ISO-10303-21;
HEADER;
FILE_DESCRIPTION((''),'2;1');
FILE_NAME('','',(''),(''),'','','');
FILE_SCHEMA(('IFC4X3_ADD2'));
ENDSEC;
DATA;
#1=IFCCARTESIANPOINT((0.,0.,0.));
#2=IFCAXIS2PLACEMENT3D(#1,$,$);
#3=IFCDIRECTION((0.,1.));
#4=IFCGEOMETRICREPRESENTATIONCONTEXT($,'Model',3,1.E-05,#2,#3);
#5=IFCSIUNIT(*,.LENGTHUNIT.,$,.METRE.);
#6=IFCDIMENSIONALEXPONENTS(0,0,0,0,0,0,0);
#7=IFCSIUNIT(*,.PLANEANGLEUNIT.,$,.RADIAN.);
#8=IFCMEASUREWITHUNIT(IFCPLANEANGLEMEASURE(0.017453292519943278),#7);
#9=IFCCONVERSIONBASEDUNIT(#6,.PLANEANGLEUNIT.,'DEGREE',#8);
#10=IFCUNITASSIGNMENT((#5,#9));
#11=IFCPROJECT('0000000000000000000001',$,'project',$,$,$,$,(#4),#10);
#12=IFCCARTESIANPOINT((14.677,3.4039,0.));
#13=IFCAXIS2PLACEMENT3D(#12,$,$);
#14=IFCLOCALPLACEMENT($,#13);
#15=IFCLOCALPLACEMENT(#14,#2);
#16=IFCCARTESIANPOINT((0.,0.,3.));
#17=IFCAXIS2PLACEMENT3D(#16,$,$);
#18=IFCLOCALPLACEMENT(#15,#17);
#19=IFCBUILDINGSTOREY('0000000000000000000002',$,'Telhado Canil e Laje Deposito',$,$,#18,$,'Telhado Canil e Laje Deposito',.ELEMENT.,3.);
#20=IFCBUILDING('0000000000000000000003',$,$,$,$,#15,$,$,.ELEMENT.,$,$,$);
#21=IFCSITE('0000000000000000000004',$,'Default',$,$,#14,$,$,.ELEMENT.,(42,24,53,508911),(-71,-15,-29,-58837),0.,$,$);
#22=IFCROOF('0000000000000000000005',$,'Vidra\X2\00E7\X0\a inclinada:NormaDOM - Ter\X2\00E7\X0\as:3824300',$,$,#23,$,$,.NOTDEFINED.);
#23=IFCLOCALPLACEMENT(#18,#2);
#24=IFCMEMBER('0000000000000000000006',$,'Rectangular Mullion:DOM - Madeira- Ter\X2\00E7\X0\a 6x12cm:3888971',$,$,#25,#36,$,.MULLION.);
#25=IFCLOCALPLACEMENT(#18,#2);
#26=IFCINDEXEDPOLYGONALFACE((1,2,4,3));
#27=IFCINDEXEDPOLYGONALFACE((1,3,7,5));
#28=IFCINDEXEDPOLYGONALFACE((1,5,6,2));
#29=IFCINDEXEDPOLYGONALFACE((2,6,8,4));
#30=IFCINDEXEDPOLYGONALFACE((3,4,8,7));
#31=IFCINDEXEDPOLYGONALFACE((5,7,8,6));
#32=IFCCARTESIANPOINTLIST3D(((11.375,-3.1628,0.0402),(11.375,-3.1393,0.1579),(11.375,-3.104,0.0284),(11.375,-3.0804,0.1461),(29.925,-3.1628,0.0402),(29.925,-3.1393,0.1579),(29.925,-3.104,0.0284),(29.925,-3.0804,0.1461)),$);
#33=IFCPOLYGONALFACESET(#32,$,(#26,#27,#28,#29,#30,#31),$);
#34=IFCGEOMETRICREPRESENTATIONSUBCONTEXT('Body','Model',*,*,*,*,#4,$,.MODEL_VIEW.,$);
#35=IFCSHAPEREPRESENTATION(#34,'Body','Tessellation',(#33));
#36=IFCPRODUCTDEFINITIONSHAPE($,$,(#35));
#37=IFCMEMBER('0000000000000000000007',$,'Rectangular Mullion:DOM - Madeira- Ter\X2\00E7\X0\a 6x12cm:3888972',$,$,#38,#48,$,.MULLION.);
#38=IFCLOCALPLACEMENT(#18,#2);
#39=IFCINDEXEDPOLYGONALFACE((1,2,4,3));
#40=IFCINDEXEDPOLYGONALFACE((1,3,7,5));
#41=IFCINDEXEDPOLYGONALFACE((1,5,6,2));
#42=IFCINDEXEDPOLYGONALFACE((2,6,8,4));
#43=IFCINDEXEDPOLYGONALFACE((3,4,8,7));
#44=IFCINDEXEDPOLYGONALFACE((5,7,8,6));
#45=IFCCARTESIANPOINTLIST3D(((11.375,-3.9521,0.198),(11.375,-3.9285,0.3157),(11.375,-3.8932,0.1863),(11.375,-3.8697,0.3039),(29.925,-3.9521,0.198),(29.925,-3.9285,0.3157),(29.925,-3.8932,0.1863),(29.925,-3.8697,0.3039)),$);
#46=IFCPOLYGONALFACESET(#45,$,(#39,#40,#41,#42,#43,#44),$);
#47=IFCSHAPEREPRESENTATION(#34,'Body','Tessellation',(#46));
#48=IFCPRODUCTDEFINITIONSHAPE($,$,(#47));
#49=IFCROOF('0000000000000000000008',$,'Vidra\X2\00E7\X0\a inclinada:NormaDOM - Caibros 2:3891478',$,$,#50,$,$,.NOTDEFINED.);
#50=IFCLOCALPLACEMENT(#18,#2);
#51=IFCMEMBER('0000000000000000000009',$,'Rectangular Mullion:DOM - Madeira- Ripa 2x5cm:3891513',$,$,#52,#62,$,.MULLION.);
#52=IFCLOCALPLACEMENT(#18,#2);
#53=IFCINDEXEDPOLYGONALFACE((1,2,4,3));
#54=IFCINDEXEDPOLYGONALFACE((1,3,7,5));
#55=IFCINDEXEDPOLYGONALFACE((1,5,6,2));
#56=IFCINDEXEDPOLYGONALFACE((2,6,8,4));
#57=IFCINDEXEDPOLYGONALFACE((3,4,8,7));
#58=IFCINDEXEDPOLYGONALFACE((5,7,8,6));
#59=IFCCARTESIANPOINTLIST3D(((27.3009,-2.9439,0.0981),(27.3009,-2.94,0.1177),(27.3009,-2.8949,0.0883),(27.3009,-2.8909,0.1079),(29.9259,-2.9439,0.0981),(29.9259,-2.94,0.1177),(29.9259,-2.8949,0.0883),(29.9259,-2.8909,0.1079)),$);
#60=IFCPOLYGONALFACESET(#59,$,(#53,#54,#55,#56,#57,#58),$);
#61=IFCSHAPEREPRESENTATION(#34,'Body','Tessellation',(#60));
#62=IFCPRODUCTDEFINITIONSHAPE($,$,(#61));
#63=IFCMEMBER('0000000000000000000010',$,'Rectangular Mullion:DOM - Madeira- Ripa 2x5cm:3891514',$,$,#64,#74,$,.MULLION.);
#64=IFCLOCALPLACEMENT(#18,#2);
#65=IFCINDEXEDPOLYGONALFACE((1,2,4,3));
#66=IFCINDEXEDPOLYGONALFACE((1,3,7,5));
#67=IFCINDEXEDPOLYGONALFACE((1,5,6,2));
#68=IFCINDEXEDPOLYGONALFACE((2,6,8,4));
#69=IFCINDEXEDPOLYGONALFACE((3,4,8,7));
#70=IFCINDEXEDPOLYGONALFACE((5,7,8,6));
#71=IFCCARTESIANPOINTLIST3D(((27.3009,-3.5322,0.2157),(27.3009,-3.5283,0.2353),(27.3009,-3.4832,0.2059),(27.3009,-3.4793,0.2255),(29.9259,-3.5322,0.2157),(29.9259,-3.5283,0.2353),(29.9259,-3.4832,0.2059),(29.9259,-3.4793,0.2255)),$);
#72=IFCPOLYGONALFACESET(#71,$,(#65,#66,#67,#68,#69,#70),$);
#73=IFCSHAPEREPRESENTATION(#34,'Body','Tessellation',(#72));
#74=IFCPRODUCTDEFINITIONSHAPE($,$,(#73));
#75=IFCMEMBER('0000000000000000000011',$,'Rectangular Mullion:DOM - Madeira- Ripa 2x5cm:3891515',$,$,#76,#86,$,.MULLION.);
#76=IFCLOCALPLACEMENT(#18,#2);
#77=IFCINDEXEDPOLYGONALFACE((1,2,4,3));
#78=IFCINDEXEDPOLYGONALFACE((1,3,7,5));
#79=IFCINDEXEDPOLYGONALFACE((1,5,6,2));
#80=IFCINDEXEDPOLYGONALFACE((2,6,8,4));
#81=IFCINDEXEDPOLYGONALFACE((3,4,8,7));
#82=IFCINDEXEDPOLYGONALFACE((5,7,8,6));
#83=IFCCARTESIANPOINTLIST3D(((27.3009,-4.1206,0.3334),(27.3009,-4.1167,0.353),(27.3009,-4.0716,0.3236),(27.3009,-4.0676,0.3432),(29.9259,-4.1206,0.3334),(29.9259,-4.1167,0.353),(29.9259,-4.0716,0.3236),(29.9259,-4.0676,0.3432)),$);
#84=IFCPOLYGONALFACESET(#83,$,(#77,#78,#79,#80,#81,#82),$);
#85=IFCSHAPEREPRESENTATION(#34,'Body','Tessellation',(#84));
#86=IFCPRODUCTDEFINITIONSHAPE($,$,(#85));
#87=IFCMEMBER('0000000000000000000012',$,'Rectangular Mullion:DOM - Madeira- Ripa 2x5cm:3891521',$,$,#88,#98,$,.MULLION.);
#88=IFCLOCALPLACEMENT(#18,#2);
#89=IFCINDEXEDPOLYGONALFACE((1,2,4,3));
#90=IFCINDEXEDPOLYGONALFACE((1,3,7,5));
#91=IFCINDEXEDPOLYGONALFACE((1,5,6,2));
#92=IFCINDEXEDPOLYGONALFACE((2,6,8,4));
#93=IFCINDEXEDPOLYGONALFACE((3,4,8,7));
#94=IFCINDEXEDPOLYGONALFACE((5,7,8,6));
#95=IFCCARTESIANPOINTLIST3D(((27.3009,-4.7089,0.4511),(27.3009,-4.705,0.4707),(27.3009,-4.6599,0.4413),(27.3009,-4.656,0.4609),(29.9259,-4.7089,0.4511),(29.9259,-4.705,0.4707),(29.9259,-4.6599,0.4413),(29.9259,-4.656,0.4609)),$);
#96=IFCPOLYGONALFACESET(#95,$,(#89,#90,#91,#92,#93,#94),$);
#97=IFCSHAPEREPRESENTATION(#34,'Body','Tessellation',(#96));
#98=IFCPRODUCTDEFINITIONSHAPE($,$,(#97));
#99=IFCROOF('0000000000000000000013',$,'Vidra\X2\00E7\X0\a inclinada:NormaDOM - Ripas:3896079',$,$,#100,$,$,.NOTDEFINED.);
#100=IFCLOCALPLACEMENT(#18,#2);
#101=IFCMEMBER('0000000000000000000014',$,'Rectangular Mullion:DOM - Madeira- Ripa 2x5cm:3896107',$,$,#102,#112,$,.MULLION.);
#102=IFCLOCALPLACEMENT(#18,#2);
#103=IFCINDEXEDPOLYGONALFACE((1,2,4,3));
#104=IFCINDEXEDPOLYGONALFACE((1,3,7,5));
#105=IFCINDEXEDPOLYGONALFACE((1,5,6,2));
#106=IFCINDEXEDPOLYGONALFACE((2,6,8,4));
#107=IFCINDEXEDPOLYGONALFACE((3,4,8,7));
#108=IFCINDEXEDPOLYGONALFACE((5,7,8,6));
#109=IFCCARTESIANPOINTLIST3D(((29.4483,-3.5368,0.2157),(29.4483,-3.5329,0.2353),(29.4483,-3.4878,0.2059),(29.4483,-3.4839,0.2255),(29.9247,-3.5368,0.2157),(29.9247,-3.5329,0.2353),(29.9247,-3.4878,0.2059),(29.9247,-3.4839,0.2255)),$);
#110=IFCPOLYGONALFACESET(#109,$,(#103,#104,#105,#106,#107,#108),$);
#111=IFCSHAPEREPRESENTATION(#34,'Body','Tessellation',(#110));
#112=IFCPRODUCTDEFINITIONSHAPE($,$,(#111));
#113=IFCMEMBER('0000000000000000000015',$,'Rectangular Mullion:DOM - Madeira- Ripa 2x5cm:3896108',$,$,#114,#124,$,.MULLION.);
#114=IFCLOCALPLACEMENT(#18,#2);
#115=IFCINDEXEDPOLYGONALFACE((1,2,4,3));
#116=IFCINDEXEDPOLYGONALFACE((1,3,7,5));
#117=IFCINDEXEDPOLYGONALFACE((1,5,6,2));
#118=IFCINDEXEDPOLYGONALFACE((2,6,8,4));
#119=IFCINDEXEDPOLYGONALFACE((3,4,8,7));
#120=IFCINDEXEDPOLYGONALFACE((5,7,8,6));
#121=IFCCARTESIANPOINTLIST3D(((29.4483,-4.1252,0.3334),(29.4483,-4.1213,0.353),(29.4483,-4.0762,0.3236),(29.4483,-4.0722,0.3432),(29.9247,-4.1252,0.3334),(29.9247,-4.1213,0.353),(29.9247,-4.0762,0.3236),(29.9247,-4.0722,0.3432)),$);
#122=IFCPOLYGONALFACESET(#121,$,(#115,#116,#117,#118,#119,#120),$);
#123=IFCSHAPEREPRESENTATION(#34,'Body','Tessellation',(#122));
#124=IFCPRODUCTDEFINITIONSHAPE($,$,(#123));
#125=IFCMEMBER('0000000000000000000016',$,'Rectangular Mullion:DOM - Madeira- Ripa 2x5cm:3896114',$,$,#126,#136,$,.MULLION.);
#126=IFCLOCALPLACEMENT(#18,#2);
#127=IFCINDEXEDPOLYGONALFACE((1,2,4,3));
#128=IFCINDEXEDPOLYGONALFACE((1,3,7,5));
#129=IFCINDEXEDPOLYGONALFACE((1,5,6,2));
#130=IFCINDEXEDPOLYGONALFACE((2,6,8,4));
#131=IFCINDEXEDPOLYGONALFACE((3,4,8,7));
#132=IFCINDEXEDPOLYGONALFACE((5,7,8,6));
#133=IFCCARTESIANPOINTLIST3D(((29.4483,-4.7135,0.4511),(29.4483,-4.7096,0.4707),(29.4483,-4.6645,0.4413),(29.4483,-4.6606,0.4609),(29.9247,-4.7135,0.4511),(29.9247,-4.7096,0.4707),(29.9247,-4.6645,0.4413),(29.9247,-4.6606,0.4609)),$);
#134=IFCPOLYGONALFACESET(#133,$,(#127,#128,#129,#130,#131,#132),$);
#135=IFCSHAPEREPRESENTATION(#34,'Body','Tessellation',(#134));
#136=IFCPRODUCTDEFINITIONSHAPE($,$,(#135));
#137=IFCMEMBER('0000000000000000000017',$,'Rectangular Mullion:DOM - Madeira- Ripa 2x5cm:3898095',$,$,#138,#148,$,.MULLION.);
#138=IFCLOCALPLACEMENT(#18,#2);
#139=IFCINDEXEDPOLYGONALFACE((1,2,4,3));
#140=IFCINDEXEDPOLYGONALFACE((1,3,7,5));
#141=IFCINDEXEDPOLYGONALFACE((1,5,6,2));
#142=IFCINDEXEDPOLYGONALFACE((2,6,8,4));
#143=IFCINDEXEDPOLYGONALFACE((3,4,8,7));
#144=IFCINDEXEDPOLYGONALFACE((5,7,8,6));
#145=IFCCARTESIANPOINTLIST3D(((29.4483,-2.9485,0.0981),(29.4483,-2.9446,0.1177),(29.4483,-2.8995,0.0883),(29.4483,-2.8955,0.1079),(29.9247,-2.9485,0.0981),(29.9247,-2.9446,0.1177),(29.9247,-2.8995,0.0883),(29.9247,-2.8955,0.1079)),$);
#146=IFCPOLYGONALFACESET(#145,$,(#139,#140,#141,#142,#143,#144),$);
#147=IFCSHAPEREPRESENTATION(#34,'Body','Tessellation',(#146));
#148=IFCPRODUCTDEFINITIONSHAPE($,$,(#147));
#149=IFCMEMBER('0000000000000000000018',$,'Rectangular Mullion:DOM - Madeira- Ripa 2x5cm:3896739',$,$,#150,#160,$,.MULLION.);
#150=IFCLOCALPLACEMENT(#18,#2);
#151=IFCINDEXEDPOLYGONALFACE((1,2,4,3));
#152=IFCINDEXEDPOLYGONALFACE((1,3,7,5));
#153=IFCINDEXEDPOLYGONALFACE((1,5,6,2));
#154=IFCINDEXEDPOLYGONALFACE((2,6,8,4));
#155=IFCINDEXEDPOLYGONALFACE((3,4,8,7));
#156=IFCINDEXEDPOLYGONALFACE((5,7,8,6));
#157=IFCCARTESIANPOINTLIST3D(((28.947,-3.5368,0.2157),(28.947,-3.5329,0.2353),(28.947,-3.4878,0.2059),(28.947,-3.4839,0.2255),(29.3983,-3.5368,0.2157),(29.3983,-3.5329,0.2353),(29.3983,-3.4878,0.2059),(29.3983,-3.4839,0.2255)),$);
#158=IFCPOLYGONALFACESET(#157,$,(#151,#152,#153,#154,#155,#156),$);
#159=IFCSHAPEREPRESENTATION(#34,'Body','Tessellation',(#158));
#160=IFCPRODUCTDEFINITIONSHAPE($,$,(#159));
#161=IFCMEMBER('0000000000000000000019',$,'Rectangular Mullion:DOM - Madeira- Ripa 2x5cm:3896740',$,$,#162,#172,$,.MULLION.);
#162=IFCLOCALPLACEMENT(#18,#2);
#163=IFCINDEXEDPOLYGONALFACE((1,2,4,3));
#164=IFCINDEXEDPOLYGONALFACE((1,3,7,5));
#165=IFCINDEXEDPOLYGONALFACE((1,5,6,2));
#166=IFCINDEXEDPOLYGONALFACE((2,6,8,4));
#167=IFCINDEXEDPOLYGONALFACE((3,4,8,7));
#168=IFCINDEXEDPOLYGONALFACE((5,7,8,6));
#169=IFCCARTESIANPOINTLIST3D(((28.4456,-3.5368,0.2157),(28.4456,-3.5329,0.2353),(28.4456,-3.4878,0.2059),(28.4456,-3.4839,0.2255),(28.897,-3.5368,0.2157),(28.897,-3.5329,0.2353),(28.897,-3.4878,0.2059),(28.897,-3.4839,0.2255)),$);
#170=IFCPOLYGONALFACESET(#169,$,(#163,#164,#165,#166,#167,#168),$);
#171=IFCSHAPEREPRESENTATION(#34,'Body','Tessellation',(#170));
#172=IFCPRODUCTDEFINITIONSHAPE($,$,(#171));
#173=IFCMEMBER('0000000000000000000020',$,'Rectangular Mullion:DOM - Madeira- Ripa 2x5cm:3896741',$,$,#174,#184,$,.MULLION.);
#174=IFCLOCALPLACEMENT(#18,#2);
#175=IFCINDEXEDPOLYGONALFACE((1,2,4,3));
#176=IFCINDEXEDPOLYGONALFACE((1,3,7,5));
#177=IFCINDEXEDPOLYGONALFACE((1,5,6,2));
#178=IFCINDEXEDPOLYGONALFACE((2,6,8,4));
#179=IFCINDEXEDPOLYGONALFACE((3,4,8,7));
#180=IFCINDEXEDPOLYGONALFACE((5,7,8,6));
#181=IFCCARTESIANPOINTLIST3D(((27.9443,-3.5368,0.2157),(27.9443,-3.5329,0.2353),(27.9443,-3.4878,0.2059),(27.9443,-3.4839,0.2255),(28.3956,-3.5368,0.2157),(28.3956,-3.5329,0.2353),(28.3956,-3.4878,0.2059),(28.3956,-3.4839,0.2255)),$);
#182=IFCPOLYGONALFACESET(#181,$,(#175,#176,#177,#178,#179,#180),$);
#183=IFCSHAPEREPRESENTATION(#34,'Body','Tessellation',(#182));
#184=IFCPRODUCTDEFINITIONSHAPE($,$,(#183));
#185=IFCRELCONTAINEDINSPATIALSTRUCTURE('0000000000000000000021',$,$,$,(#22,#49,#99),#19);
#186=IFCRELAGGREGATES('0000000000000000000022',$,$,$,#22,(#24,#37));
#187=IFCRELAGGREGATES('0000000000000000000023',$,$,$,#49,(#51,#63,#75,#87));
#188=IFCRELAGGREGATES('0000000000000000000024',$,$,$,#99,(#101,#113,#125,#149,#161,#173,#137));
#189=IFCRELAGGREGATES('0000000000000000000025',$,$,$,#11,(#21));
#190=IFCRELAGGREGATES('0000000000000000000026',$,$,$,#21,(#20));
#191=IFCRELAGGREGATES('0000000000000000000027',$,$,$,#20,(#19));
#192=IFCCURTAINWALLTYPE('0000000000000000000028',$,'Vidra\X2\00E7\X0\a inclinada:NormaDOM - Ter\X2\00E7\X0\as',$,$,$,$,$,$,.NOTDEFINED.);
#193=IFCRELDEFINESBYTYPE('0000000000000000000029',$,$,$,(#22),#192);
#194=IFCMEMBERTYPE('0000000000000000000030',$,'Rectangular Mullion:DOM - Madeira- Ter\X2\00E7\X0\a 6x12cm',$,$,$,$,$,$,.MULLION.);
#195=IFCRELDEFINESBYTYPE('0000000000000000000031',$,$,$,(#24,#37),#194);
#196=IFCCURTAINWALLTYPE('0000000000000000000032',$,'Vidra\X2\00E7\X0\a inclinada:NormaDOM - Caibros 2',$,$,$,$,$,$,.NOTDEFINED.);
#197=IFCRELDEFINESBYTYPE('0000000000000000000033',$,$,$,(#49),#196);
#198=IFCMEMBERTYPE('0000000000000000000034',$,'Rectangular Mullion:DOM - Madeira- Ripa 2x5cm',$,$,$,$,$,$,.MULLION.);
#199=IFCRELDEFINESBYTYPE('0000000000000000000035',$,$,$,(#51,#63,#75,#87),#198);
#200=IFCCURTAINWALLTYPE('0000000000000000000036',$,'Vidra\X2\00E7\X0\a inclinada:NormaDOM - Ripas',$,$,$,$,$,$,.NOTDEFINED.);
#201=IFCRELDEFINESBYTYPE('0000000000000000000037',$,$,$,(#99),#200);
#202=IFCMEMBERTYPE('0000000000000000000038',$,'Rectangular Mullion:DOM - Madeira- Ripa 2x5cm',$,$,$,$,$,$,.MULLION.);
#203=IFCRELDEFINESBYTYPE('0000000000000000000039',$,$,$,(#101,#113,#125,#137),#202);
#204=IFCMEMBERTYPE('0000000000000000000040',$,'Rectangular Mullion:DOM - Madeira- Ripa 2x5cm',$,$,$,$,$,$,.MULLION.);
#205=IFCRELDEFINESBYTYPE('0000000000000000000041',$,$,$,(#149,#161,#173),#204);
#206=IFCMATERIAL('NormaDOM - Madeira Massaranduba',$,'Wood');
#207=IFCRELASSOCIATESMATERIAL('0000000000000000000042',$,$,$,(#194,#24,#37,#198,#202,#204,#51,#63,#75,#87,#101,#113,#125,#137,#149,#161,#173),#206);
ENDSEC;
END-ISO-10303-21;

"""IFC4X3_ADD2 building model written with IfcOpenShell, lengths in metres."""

from ifc_helpers import new_model, entity, si_unit, converted_unit, direction, frame, origin, origin_2d_with_axis, place, context, subcontext, project, spatial, rectangle, extrude, source, transform, mapped, material, material_profile, profile_set, profile_usage, type_object, type_shapes, element, aggregate, save


model = new_model("IFC4X3_ADD2")

# Units and contexts
model_context = context("Model", 3, precision=1e-05, world=origin(), true_north=direction((0.0, 1.0)))
body_context = subcontext(model_context, "Body", "Model", "MODEL_VIEW")
ifc_project = project(units=[si_unit("LENGTHUNIT", "METRE"), converted_unit("PLANEANGLEUNIT", "DEGREE", entity("IfcPlaneAngleMeasure", 0.017453292519943278), si_unit("PLANEANGLEUNIT", "RADIAN"), dimensions=[0, 0, 0, 0, 0, 0, 0])], contexts=[model_context])

# Site, building, storey
site_placement = place(None, frame((14.677, 3.4039, 0.0)))
site = spatial("IfcSite", under=ifc_project, at=site_placement, Name="Default", CompositionType="ELEMENT", RefLatitude=(42, 24, 53, 508911), RefLongitude=(-71, -15, -29, -58837), RefElevation=0.0)
building_placement = place(site_placement, origin())
building = spatial("IfcBuilding", under=site, at=building_placement, CompositionType="ELEMENT")
storey_placement = place(building_placement, frame((0.0, 0.0, 3.0)))
storey = spatial("IfcBuildingStorey", under=building, at=storey_placement, Name="Telhado Canil e Laje Deposito", LongName="Telhado Canil e Laje Deposito", CompositionType="ELEMENT", Elevation=3.0)

# Roofs, members
curtain_wall_type_1 = type_object("IfcCurtainWallType", Name="Vidraça inclinada:NormaDOM - Terças", PredefinedType="NOTDEFINED")
roof_1_placement = place(storey_placement, frame((0.0, 0.0, -3.0)))
roof_1 = element("IfcRoof", 1, at=roof_1_placement, inside=storey, type_object=curtain_wall_type_1, Name="Vidraça inclinada:NormaDOM - Terças:3824300", PredefinedType="NOTDEFINED")
ifc_material = material(Name="NormaDOM - Madeira Massaranduba", Category="Wood")
ifc_material_profile_1 = material_profile(ifc_material, rectangle(XDim=0.06, YDim=0.12, at=origin_2d_with_axis()), Name="DOM - Madeira- Terça 6x12cm")
ifc_profile_set_1 = profile_set([ifc_material_profile_1], Name="DOM - Madeira- Terça 6x12cm")
ifc_profile_usage_1 = profile_usage(ifc_profile_set_1)
member_type_1 = type_object("IfcMemberType", Name="Rectangular Mullion:DOM - Madeira- Terça 6x12cm", PredefinedType="MULLION", material=ifc_profile_set_1)
shared_shape_1 = source(origin(), body_context, "Body", "SweptSolid", [
    extrude(rectangle(XDim=0.06, YDim=0.12, at=origin_2d_with_axis()), frame((0.0, 0.06, -18.55), z_axis=(0.0, 0.0, 1.0), x_axis=(-1.0, 0.0, 0.0)), (0.0, 0.0, 1.0), 18.55),
])
type_shapes(member_type_1, [shared_shape_1])
member_1_placement = place(roof_1_placement, frame((29.925, -3.1098, 3.152), z_axis=(1.0, 0.0, 0.0), x_axis=(0.0, -0.980581, 0.196116)))
member_1 = element("IfcMember", 2, at=member_1_placement, type_object=member_type_1, material=ifc_profile_usage_1, Name="Rectangular Mullion:DOM - Madeira- Terça 6x12cm:3888971", PredefinedType="MULLION", context=body_context, shape_type="MappedRepresentation", body=[
    mapped(shared_shape_1, transform((0.0, 0.0, 0.0), scale=1.0)),
])
member_2_placement = place(roof_1_placement, frame((29.925, -3.8991, 3.3098), z_axis=(1.0, 0.0, 0.0), x_axis=(0.0, -0.980581, 0.196116)))
member_2 = element("IfcMember", 3, at=member_2_placement, type_object=member_type_1, material=ifc_profile_usage_1, Name="Rectangular Mullion:DOM - Madeira- Terça 6x12cm:3888972", PredefinedType="MULLION", context=body_context, shape_type="MappedRepresentation", body=[
    mapped(shared_shape_1, transform((0.0, 0.0, 0.0), scale=1.0)),
])
aggregate(roof_1, [member_1, member_2])
curtain_wall_type_2 = type_object("IfcCurtainWallType", Name="Vidraça inclinada:NormaDOM - Caibros 2", PredefinedType="NOTDEFINED")
roof_2_placement = place(storey_placement, frame((0.0, 0.0, -3.0)))
roof_2 = element("IfcRoof", 4, at=roof_2_placement, inside=storey, type_object=curtain_wall_type_2, Name="Vidraça inclinada:NormaDOM - Caibros 2:3891478", PredefinedType="NOTDEFINED")
ifc_material_profile_2 = material_profile(ifc_material, rectangle(XDim=0.05, YDim=0.02, at=origin_2d_with_axis()), Name="DOM - Madeira- Ripa 2x5cm")
ifc_profile_set_2 = profile_set([ifc_material_profile_2], Name="DOM - Madeira- Ripa 2x5cm")
ifc_profile_usage_2 = profile_usage(ifc_profile_set_2)
member_type_2 = type_object("IfcMemberType", Name="Rectangular Mullion:DOM - Madeira- Ripa 2x5cm", PredefinedType="MULLION", material=ifc_profile_set_2)
shared_shape_2 = source(origin(), body_context, "Body", "SweptSolid", [
    extrude(rectangle(XDim=0.05, YDim=0.02, at=origin_2d_with_axis()), frame((0.025, 0.01, -2.625), z_axis=(0.0, 0.0, 1.0), x_axis=(-1.0, 0.0, 0.0)), (0.0, 0.0, 1.0), 2.625),
])
type_shapes(member_type_2, [shared_shape_2])
member_3_placement = place(roof_2_placement, frame((29.9259, -2.8909, 3.1079), z_axis=(1.0, 0.0, 0.0), x_axis=(0.0, -0.980581, 0.196116)))
member_3 = element("IfcMember", 5, at=member_3_placement, type_object=member_type_2, material=ifc_profile_usage_2, Name="Rectangular Mullion:DOM - Madeira- Ripa 2x5cm:3891513", PredefinedType="MULLION", context=body_context, shape_type="MappedRepresentation", body=[
    mapped(shared_shape_2, transform((0.0, 0.0, 0.0), scale=1.0)),
])
member_4_placement = place(roof_2_placement, frame((29.9259, -3.4793, 3.2255), z_axis=(1.0, 0.0, 0.0), x_axis=(0.0, -0.980581, 0.196116)))
member_4 = element("IfcMember", 6, at=member_4_placement, type_object=member_type_2, material=ifc_profile_usage_2, Name="Rectangular Mullion:DOM - Madeira- Ripa 2x5cm:3891514", PredefinedType="MULLION", context=body_context, shape_type="MappedRepresentation", body=[
    mapped(shared_shape_2, transform((0.0, 0.0, 0.0), scale=1.0)),
])
member_5_placement = place(roof_2_placement, frame((29.9259, -4.0676, 3.3432), z_axis=(1.0, 0.0, 0.0), x_axis=(0.0, -0.980581, 0.196116)))
member_5 = element("IfcMember", 7, at=member_5_placement, type_object=member_type_2, material=ifc_profile_usage_2, Name="Rectangular Mullion:DOM - Madeira- Ripa 2x5cm:3891515", PredefinedType="MULLION", context=body_context, shape_type="MappedRepresentation", body=[
    mapped(shared_shape_2, transform((0.0, 0.0, 0.0), scale=1.0)),
])
member_6_placement = place(roof_2_placement, frame((29.9259, -4.656, 3.4609), z_axis=(1.0, 0.0, 0.0), x_axis=(0.0, -0.980581, 0.196116)))
member_6 = element("IfcMember", 8, at=member_6_placement, type_object=member_type_2, material=ifc_profile_usage_2, Name="Rectangular Mullion:DOM - Madeira- Ripa 2x5cm:3891521", PredefinedType="MULLION", context=body_context, shape_type="MappedRepresentation", body=[
    mapped(shared_shape_2, transform((0.0, 0.0, 0.0), scale=1.0)),
])
aggregate(roof_2, [member_3, member_4, member_5, member_6])
curtain_wall_type_3 = type_object("IfcCurtainWallType", Name="Vidraça inclinada:NormaDOM - Ripas", PredefinedType="NOTDEFINED")
roof_3_placement = place(storey_placement, frame((0.0, 0.0, -3.0)))
roof_3 = element("IfcRoof", 9, at=roof_3_placement, inside=storey, type_object=curtain_wall_type_3, Name="Vidraça inclinada:NormaDOM - Ripas:3896079", PredefinedType="NOTDEFINED")
member_type_3 = type_object("IfcMemberType", Name="Rectangular Mullion:DOM - Madeira- Ripa 2x5cm", PredefinedType="MULLION", material=ifc_profile_set_2)
shared_shape_3 = source(origin(), body_context, "Body", "SweptSolid", [
    extrude(rectangle(XDim=0.05, YDim=0.02, at=origin_2d_with_axis()), frame((0.025, 0.01, -0.4764), z_axis=(0.0, 0.0, 1.0), x_axis=(-1.0, 0.0, 0.0)), (0.0, 0.0, 1.0), 0.4764),
])
type_shapes(member_type_3, [shared_shape_3])
member_7_placement = place(roof_3_placement, frame((29.9247, -3.4839, 3.2255), z_axis=(1.0, 0.0, 0.0), x_axis=(0.0, -0.980581, 0.196116)))
member_7 = element("IfcMember", 10, at=member_7_placement, type_object=member_type_3, material=ifc_profile_usage_2, Name="Rectangular Mullion:DOM - Madeira- Ripa 2x5cm:3896107", PredefinedType="MULLION", context=body_context, shape_type="MappedRepresentation", body=[
    mapped(shared_shape_3, transform((0.0, 0.0, 0.0), scale=1.0)),
])
member_8_placement = place(roof_3_placement, frame((29.9247, -4.0722, 3.3432), z_axis=(1.0, 0.0, 0.0), x_axis=(0.0, -0.980581, 0.196116)))
member_8 = element("IfcMember", 11, at=member_8_placement, type_object=member_type_3, material=ifc_profile_usage_2, Name="Rectangular Mullion:DOM - Madeira- Ripa 2x5cm:3896108", PredefinedType="MULLION", context=body_context, shape_type="MappedRepresentation", body=[
    mapped(shared_shape_3, transform((0.0, 0.0, 0.0), scale=1.0)),
])
member_9_placement = place(roof_3_placement, frame((29.9247, -4.6606, 3.4609), z_axis=(1.0, 0.0, 0.0), x_axis=(0.0, -0.980581, 0.196116)))
member_9 = element("IfcMember", 12, at=member_9_placement, type_object=member_type_3, material=ifc_profile_usage_2, Name="Rectangular Mullion:DOM - Madeira- Ripa 2x5cm:3896114", PredefinedType="MULLION", context=body_context, shape_type="MappedRepresentation", body=[
    mapped(shared_shape_3, transform((0.0, 0.0, 0.0), scale=1.0)),
])
member_10_placement = place(roof_3_placement, frame((29.9247, -2.8955, 3.1079), z_axis=(1.0, 0.0, 0.0), x_axis=(0.0, -0.980581, 0.196116)))
member_10 = element("IfcMember", 13, at=member_10_placement, type_object=member_type_3, material=ifc_profile_usage_2, Name="Rectangular Mullion:DOM - Madeira- Ripa 2x5cm:3898095", PredefinedType="MULLION", context=body_context, shape_type="MappedRepresentation", body=[
    mapped(shared_shape_3, transform((0.0, 0.0, 0.0), scale=1.0)),
])
member_type_4 = type_object("IfcMemberType", Name="Rectangular Mullion:DOM - Madeira- Ripa 2x5cm", PredefinedType="MULLION", material=ifc_profile_set_2)
shared_shape_4 = source(origin(), body_context, "Body", "SweptSolid", [
    extrude(rectangle(XDim=0.05, YDim=0.02, at=origin_2d_with_axis()), frame((0.025, 0.01, -0.4514), z_axis=(0.0, 0.0, 1.0), x_axis=(-1.0, 0.0, 0.0)), (0.0, 0.0, 1.0), 0.4514),
])
type_shapes(member_type_4, [shared_shape_4])
member_11_placement = place(roof_3_placement, frame((29.3983, -3.4839, 3.2255), z_axis=(1.0, 0.0, 0.0), x_axis=(0.0, -0.980581, 0.196116)))
member_11 = element("IfcMember", 14, at=member_11_placement, type_object=member_type_4, material=ifc_profile_usage_2, Name="Rectangular Mullion:DOM - Madeira- Ripa 2x5cm:3896739", PredefinedType="MULLION", context=body_context, shape_type="MappedRepresentation", body=[
    mapped(shared_shape_4, transform((0.0, 0.0, 0.0), scale=1.0)),
])
member_12_placement = place(roof_3_placement, frame((28.897, -3.4839, 3.2255), z_axis=(1.0, 0.0, 0.0), x_axis=(0.0, -0.980581, 0.196116)))
member_12 = element("IfcMember", 15, at=member_12_placement, type_object=member_type_4, material=ifc_profile_usage_2, Name="Rectangular Mullion:DOM - Madeira- Ripa 2x5cm:3896740", PredefinedType="MULLION", context=body_context, shape_type="MappedRepresentation", body=[
    mapped(shared_shape_4, transform((0.0, 0.0, 0.0), scale=1.0)),
])
member_13_placement = place(roof_3_placement, frame((28.3956, -3.4839, 3.2255), z_axis=(1.0, 0.0, 0.0), x_axis=(0.0, -0.980581, 0.196116)))
member_13 = element("IfcMember", 16, at=member_13_placement, type_object=member_type_4, material=ifc_profile_usage_2, Name="Rectangular Mullion:DOM - Madeira- Ripa 2x5cm:3896741", PredefinedType="MULLION", context=body_context, shape_type="MappedRepresentation", body=[
    mapped(shared_shape_4, transform((0.0, 0.0, 0.0), scale=1.0)),
])
aggregate(roof_3, [member_7, member_8, member_9, member_11, member_12, member_13, member_10])

save(model, "model.ifc")
